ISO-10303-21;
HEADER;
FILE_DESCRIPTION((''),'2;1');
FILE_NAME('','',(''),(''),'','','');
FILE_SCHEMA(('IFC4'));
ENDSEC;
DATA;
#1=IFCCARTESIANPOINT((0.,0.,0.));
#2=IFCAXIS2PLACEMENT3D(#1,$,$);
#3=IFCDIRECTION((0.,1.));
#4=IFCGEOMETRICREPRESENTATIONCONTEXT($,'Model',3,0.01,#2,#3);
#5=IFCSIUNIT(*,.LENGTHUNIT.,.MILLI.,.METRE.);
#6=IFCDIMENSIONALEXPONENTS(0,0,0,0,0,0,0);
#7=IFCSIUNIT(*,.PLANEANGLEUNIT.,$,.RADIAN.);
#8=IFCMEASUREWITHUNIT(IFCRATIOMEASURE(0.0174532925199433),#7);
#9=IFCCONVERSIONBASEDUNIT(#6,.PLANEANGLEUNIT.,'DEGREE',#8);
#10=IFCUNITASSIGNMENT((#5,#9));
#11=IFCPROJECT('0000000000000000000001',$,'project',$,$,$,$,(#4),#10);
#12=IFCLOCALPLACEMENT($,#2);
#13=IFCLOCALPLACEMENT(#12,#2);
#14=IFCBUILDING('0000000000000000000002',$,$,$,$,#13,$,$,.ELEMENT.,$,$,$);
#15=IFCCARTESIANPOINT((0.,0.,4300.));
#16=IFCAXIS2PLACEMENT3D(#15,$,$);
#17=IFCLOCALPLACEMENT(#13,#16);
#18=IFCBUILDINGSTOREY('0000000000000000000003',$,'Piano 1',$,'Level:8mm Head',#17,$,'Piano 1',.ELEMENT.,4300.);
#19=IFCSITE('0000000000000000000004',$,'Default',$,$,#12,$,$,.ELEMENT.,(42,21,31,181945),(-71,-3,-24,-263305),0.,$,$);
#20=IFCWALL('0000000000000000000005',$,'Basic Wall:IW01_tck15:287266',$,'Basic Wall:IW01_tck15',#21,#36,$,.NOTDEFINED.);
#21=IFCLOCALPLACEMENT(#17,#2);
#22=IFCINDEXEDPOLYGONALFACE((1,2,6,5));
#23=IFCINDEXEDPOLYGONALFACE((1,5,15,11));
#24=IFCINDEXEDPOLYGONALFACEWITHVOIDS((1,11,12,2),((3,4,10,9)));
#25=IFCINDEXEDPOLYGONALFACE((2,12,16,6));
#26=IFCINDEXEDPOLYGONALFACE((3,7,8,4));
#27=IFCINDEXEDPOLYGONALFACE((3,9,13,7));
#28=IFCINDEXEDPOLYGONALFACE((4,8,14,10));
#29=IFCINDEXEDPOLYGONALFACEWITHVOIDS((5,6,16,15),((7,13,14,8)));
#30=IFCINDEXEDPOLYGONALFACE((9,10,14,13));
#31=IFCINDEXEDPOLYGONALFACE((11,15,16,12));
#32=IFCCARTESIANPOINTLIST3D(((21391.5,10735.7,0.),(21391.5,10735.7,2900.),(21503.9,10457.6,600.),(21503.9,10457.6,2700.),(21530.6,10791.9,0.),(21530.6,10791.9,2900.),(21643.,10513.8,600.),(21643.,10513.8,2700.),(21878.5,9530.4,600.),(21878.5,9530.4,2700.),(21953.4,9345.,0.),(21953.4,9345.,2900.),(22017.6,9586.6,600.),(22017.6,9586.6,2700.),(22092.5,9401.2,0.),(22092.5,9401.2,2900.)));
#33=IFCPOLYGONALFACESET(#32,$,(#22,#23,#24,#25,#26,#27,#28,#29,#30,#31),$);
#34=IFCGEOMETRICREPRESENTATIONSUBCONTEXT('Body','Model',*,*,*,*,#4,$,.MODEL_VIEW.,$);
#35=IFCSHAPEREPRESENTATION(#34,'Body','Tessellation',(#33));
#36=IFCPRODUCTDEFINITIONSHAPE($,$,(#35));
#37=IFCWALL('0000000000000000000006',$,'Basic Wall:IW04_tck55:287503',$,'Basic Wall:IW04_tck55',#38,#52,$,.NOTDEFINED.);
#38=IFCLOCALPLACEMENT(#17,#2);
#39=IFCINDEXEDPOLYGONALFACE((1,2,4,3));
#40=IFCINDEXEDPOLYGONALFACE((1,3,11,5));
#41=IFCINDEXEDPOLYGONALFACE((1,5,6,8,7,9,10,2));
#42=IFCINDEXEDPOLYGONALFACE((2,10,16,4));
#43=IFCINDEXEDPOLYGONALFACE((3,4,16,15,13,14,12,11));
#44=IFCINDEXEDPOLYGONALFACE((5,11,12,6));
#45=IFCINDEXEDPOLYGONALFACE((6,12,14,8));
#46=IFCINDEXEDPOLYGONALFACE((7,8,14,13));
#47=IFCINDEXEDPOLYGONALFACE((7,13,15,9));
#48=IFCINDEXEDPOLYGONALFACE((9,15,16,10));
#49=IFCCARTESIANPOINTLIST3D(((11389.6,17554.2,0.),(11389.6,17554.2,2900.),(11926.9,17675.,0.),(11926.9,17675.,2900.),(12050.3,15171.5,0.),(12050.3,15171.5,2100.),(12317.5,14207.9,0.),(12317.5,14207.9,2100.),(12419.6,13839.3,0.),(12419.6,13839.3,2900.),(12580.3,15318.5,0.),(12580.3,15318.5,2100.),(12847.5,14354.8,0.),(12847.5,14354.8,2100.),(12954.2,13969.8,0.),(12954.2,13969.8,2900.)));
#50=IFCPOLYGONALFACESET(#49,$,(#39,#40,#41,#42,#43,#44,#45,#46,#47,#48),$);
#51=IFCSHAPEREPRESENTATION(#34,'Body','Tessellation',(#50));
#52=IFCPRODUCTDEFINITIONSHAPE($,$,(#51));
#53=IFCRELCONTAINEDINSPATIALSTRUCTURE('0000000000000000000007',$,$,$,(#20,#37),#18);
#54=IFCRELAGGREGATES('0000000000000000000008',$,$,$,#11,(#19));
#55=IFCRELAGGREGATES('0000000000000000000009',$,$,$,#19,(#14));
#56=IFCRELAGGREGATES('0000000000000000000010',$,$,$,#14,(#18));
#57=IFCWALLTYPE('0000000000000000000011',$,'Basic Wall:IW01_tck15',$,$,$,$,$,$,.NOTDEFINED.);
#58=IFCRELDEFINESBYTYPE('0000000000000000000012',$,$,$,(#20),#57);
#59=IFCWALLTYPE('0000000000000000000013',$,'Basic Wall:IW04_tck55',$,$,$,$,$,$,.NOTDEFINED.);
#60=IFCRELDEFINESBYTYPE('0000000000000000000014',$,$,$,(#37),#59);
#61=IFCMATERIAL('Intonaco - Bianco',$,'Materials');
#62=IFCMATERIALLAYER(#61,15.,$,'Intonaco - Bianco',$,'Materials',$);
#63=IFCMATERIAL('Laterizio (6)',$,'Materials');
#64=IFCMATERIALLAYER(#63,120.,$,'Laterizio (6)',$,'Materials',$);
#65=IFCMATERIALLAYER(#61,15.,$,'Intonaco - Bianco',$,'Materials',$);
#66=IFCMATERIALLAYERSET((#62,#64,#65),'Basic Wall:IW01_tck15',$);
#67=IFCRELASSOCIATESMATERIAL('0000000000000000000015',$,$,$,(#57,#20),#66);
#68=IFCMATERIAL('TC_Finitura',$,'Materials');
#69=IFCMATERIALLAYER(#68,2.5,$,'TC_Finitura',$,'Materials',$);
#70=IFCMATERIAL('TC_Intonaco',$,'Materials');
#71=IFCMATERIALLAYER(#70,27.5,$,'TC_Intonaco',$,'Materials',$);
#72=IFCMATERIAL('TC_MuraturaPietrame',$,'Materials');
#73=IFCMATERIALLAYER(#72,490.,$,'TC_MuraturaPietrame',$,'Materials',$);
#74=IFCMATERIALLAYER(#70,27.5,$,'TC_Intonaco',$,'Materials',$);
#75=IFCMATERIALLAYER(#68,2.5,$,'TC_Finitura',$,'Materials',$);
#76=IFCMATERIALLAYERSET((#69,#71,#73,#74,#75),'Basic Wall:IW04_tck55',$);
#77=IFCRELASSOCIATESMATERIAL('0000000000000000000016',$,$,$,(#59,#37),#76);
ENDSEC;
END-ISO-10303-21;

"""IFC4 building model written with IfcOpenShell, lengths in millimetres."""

from ifc_helpers import new_model, entity, si_unit, converted_unit, direction, frame, frame_2d, origin, place, context, subcontext, project, spatial, polyline, rectangle, outline, extrude, clip, bounded_halfspace, material, layer, layer_set, layer_usage, type_object, element, save


model = new_model("IFC4")

# Units and contexts
model_context = context("Model", 3, precision=0.01, world=origin(), true_north=direction((0.0, 1.0)))
body_context = subcontext(model_context, "Body", "Model", "MODEL_VIEW")
ifc_project = project(units=[si_unit("LENGTHUNIT", "METRE", prefix="MILLI"), converted_unit("PLANEANGLEUNIT", "DEGREE", entity("IfcRatioMeasure", 0.0174532925199433), si_unit("PLANEANGLEUNIT", "RADIAN"), dimensions=[0, 0, 0, 0, 0, 0, 0])], contexts=[model_context])

# Site, building, storey
site_placement = place(None, origin())
site = spatial("IfcSite", under=ifc_project, at=site_placement, Name="Default", CompositionType="ELEMENT", RefLatitude=(42, 21, 31, 181945), RefLongitude=(-71, -3, -24, -263305), RefElevation=0.0)
building_placement = place(site_placement, origin())
building = spatial("IfcBuilding", under=site, at=building_placement, CompositionType="ELEMENT")
storey_placement = place(building_placement, frame((0.0, 0.0, 4300.0)))
storey = spatial("IfcBuildingStorey", under=building, at=storey_placement, Name="Piano 1", ObjectType="Level:8mm Head", LongName="Piano 1", CompositionType="ELEMENT", Elevation=4300.0)

# Shared definitions
ifc_material_1 = material(Name="TC_Finitura", Category="Materials")
ifc_material_2 = material(Name="TC_Intonaco", Category="Materials")
ifc_material_3 = material(Name="TC_MuraturaPietrame", Category="Materials")

# Walls, openings
ifc_material_4 = material(Name="Intonaco - Bianco", Category="Materials")
ifc_layer_1 = layer(ifc_material_4, 15.0, Name="Intonaco - Bianco", Category="Materials")
ifc_material_5 = material(Name="Laterizio (6)", Category="Materials")
ifc_layer_2 = layer(ifc_material_5, 120.0, Name="Laterizio (6)", Category="Materials")
ifc_layer_3 = layer(ifc_material_4, 15.0, Name="Intonaco - Bianco", Category="Materials")
ifc_layer_set_1 = layer_set([ifc_layer_1, ifc_layer_2, ifc_layer_3], Name="Basic Wall:IW01_tck15")
wall_type_1 = type_object("IfcWallType", Name="Basic Wall:IW01_tck15", PredefinedType="NOTDEFINED", material=ifc_layer_set_1)
ifc_layer_usage_1 = layer_usage(ifc_layer_set_1, "AXIS2", "NEGATIVE", 75.0)
wall_1_placement = place(storey_placement, frame((21461.1, 10763.8, 0.0), z_axis=(0.0, 0.0, 1.0), x_axis=(0.374607, -0.927184, 0.0)))
wall_1 = element("IfcWall", 1, at=wall_1_placement, inside=storey, type_object=wall_type_1, material=ifc_layer_usage_1, Name="Basic Wall:IW01_tck15:287266", ObjectType="Basic Wall:IW01_tck15", PredefinedType="NOTDEFINED", context=body_context, shape_type="Clipping", body=[
    clip(extrude(rectangle(XDim=1500.0, YDim=150.0, at=frame_2d((750.0, 0.0), x_axis=(-1.0, 0.0))), origin(), (0.0, 0.0, 1.0), 2900.0), bounded_halfspace(frame((0.0, -75.0, 2900.0), z_axis=(0.0, 0.0, -1.0), x_axis=(0.109562, 0.99398, 0.0)), True, frame((0.0, -75.0, 2900.0)), polyline([(0.0, 0.0), (1500.0, 0.0), (1500.0, 150.0), (0.0, 150.0), (0.0, 0.0)]))),
])
opening_1_placement = place(wall_1_placement, frame((300.0, -75.0, 600.0)))
element("IfcOpeningElement", 2, at=opening_1_placement, cuts=wall_1, ObjectType="Opening", PredefinedType="OPENING", context=body_context, shape_type="SweptSolid", body=[
    extrude(rectangle(XDim=2100.0, YDim=1000.0, at=frame_2d((1050.0, 500.0), x_axis=(1.0, 0.0))), frame((0.0, 0.0, 0.0), z_axis=(0.0, 1.0, 0.0), x_axis=(0.0, 0.0, 1.0)), (0.0, 0.0, 1.0), 150.0),
])
ifc_layer_4 = layer(ifc_material_1, 2.5, Name="TC_Finitura", Category="Materials")
ifc_layer_5 = layer(ifc_material_2, 27.5, Name="TC_Intonaco", Category="Materials")
ifc_layer_6 = layer(ifc_material_3, 490.0, Name="TC_MuraturaPietrame", Category="Materials")
ifc_layer_7 = layer(ifc_material_2, 27.5, Name="TC_Intonaco", Category="Materials")
ifc_layer_8 = layer(ifc_material_1, 2.5, Name="TC_Finitura", Category="Materials")
ifc_layer_set_2 = layer_set([ifc_layer_4, ifc_layer_5, ifc_layer_6, ifc_layer_7, ifc_layer_8], Name="Basic Wall:IW04_tck55")
ifc_layer_usage_2 = layer_usage(ifc_layer_set_2, "AXIS2", "NEGATIVE", 275.0)
wall_type_2 = type_object("IfcWallType", Name="Basic Wall:IW04_tck55", PredefinedType="NOTDEFINED", material=ifc_layer_set_2)
wall_2_placement = place(storey_placement, frame((11654.7, 17627.6, 0.0), z_axis=(0.0, 0.0, 1.0), x_axis=(0.267184, -0.963646, 0.0)))
wall_2 = element("IfcWall", 3, at=wall_2_placement, inside=storey, type_object=wall_type_2, material=ifc_layer_usage_2, Name="Basic Wall:IW04_tck55:287503", ObjectType="Basic Wall:IW04_tck55", PredefinedType="NOTDEFINED", context=body_context, shape_type="Clipping", body=[
    clip(extrude(outline(polyline([(0.0, -275.0), (2039.5, -275.0), (2189.6, -275.0), (3855.0, -275.0), (3872.1, 275.0), (27.1, 275.0), (0.0, -275.0)])), origin(), (0.0, 0.0, 1.0), 2900.0), bounded_halfspace(frame((0.0, -275.0, 2900.0), z_axis=(0.0, 0.0, -1.0), x_axis=(-0.003721, 0.999993, 0.0)), True, frame((0.0, -275.0, 2900.0)), polyline([(0.0, 0.0), (2039.5, 0.0), (2189.6, 0.0), (3855.0, 0.0), (3872.1, 550.0), (27.1, 550.0), (0.0, 0.0)]))),
])
opening_2_placement = place(wall_2_placement, frame((2472.5, -275.0, 0.0)))
element("IfcOpeningElement", 4, at=opening_2_placement, cuts=wall_2, ObjectType="Opening", PredefinedType="OPENING", context=body_context, shape_type="SweptSolid", body=[
    extrude(rectangle(XDim=2100.0, YDim=1000.0, at=frame_2d((1050.0, 500.0), x_axis=(1.0, 0.0))), frame((0.0, 0.0, 0.0), z_axis=(0.0, 1.0, 0.0), x_axis=(0.0, 0.0, 1.0)), (0.0, 0.0, 1.0), 550.0),
])

save(model, "model.ifc")
